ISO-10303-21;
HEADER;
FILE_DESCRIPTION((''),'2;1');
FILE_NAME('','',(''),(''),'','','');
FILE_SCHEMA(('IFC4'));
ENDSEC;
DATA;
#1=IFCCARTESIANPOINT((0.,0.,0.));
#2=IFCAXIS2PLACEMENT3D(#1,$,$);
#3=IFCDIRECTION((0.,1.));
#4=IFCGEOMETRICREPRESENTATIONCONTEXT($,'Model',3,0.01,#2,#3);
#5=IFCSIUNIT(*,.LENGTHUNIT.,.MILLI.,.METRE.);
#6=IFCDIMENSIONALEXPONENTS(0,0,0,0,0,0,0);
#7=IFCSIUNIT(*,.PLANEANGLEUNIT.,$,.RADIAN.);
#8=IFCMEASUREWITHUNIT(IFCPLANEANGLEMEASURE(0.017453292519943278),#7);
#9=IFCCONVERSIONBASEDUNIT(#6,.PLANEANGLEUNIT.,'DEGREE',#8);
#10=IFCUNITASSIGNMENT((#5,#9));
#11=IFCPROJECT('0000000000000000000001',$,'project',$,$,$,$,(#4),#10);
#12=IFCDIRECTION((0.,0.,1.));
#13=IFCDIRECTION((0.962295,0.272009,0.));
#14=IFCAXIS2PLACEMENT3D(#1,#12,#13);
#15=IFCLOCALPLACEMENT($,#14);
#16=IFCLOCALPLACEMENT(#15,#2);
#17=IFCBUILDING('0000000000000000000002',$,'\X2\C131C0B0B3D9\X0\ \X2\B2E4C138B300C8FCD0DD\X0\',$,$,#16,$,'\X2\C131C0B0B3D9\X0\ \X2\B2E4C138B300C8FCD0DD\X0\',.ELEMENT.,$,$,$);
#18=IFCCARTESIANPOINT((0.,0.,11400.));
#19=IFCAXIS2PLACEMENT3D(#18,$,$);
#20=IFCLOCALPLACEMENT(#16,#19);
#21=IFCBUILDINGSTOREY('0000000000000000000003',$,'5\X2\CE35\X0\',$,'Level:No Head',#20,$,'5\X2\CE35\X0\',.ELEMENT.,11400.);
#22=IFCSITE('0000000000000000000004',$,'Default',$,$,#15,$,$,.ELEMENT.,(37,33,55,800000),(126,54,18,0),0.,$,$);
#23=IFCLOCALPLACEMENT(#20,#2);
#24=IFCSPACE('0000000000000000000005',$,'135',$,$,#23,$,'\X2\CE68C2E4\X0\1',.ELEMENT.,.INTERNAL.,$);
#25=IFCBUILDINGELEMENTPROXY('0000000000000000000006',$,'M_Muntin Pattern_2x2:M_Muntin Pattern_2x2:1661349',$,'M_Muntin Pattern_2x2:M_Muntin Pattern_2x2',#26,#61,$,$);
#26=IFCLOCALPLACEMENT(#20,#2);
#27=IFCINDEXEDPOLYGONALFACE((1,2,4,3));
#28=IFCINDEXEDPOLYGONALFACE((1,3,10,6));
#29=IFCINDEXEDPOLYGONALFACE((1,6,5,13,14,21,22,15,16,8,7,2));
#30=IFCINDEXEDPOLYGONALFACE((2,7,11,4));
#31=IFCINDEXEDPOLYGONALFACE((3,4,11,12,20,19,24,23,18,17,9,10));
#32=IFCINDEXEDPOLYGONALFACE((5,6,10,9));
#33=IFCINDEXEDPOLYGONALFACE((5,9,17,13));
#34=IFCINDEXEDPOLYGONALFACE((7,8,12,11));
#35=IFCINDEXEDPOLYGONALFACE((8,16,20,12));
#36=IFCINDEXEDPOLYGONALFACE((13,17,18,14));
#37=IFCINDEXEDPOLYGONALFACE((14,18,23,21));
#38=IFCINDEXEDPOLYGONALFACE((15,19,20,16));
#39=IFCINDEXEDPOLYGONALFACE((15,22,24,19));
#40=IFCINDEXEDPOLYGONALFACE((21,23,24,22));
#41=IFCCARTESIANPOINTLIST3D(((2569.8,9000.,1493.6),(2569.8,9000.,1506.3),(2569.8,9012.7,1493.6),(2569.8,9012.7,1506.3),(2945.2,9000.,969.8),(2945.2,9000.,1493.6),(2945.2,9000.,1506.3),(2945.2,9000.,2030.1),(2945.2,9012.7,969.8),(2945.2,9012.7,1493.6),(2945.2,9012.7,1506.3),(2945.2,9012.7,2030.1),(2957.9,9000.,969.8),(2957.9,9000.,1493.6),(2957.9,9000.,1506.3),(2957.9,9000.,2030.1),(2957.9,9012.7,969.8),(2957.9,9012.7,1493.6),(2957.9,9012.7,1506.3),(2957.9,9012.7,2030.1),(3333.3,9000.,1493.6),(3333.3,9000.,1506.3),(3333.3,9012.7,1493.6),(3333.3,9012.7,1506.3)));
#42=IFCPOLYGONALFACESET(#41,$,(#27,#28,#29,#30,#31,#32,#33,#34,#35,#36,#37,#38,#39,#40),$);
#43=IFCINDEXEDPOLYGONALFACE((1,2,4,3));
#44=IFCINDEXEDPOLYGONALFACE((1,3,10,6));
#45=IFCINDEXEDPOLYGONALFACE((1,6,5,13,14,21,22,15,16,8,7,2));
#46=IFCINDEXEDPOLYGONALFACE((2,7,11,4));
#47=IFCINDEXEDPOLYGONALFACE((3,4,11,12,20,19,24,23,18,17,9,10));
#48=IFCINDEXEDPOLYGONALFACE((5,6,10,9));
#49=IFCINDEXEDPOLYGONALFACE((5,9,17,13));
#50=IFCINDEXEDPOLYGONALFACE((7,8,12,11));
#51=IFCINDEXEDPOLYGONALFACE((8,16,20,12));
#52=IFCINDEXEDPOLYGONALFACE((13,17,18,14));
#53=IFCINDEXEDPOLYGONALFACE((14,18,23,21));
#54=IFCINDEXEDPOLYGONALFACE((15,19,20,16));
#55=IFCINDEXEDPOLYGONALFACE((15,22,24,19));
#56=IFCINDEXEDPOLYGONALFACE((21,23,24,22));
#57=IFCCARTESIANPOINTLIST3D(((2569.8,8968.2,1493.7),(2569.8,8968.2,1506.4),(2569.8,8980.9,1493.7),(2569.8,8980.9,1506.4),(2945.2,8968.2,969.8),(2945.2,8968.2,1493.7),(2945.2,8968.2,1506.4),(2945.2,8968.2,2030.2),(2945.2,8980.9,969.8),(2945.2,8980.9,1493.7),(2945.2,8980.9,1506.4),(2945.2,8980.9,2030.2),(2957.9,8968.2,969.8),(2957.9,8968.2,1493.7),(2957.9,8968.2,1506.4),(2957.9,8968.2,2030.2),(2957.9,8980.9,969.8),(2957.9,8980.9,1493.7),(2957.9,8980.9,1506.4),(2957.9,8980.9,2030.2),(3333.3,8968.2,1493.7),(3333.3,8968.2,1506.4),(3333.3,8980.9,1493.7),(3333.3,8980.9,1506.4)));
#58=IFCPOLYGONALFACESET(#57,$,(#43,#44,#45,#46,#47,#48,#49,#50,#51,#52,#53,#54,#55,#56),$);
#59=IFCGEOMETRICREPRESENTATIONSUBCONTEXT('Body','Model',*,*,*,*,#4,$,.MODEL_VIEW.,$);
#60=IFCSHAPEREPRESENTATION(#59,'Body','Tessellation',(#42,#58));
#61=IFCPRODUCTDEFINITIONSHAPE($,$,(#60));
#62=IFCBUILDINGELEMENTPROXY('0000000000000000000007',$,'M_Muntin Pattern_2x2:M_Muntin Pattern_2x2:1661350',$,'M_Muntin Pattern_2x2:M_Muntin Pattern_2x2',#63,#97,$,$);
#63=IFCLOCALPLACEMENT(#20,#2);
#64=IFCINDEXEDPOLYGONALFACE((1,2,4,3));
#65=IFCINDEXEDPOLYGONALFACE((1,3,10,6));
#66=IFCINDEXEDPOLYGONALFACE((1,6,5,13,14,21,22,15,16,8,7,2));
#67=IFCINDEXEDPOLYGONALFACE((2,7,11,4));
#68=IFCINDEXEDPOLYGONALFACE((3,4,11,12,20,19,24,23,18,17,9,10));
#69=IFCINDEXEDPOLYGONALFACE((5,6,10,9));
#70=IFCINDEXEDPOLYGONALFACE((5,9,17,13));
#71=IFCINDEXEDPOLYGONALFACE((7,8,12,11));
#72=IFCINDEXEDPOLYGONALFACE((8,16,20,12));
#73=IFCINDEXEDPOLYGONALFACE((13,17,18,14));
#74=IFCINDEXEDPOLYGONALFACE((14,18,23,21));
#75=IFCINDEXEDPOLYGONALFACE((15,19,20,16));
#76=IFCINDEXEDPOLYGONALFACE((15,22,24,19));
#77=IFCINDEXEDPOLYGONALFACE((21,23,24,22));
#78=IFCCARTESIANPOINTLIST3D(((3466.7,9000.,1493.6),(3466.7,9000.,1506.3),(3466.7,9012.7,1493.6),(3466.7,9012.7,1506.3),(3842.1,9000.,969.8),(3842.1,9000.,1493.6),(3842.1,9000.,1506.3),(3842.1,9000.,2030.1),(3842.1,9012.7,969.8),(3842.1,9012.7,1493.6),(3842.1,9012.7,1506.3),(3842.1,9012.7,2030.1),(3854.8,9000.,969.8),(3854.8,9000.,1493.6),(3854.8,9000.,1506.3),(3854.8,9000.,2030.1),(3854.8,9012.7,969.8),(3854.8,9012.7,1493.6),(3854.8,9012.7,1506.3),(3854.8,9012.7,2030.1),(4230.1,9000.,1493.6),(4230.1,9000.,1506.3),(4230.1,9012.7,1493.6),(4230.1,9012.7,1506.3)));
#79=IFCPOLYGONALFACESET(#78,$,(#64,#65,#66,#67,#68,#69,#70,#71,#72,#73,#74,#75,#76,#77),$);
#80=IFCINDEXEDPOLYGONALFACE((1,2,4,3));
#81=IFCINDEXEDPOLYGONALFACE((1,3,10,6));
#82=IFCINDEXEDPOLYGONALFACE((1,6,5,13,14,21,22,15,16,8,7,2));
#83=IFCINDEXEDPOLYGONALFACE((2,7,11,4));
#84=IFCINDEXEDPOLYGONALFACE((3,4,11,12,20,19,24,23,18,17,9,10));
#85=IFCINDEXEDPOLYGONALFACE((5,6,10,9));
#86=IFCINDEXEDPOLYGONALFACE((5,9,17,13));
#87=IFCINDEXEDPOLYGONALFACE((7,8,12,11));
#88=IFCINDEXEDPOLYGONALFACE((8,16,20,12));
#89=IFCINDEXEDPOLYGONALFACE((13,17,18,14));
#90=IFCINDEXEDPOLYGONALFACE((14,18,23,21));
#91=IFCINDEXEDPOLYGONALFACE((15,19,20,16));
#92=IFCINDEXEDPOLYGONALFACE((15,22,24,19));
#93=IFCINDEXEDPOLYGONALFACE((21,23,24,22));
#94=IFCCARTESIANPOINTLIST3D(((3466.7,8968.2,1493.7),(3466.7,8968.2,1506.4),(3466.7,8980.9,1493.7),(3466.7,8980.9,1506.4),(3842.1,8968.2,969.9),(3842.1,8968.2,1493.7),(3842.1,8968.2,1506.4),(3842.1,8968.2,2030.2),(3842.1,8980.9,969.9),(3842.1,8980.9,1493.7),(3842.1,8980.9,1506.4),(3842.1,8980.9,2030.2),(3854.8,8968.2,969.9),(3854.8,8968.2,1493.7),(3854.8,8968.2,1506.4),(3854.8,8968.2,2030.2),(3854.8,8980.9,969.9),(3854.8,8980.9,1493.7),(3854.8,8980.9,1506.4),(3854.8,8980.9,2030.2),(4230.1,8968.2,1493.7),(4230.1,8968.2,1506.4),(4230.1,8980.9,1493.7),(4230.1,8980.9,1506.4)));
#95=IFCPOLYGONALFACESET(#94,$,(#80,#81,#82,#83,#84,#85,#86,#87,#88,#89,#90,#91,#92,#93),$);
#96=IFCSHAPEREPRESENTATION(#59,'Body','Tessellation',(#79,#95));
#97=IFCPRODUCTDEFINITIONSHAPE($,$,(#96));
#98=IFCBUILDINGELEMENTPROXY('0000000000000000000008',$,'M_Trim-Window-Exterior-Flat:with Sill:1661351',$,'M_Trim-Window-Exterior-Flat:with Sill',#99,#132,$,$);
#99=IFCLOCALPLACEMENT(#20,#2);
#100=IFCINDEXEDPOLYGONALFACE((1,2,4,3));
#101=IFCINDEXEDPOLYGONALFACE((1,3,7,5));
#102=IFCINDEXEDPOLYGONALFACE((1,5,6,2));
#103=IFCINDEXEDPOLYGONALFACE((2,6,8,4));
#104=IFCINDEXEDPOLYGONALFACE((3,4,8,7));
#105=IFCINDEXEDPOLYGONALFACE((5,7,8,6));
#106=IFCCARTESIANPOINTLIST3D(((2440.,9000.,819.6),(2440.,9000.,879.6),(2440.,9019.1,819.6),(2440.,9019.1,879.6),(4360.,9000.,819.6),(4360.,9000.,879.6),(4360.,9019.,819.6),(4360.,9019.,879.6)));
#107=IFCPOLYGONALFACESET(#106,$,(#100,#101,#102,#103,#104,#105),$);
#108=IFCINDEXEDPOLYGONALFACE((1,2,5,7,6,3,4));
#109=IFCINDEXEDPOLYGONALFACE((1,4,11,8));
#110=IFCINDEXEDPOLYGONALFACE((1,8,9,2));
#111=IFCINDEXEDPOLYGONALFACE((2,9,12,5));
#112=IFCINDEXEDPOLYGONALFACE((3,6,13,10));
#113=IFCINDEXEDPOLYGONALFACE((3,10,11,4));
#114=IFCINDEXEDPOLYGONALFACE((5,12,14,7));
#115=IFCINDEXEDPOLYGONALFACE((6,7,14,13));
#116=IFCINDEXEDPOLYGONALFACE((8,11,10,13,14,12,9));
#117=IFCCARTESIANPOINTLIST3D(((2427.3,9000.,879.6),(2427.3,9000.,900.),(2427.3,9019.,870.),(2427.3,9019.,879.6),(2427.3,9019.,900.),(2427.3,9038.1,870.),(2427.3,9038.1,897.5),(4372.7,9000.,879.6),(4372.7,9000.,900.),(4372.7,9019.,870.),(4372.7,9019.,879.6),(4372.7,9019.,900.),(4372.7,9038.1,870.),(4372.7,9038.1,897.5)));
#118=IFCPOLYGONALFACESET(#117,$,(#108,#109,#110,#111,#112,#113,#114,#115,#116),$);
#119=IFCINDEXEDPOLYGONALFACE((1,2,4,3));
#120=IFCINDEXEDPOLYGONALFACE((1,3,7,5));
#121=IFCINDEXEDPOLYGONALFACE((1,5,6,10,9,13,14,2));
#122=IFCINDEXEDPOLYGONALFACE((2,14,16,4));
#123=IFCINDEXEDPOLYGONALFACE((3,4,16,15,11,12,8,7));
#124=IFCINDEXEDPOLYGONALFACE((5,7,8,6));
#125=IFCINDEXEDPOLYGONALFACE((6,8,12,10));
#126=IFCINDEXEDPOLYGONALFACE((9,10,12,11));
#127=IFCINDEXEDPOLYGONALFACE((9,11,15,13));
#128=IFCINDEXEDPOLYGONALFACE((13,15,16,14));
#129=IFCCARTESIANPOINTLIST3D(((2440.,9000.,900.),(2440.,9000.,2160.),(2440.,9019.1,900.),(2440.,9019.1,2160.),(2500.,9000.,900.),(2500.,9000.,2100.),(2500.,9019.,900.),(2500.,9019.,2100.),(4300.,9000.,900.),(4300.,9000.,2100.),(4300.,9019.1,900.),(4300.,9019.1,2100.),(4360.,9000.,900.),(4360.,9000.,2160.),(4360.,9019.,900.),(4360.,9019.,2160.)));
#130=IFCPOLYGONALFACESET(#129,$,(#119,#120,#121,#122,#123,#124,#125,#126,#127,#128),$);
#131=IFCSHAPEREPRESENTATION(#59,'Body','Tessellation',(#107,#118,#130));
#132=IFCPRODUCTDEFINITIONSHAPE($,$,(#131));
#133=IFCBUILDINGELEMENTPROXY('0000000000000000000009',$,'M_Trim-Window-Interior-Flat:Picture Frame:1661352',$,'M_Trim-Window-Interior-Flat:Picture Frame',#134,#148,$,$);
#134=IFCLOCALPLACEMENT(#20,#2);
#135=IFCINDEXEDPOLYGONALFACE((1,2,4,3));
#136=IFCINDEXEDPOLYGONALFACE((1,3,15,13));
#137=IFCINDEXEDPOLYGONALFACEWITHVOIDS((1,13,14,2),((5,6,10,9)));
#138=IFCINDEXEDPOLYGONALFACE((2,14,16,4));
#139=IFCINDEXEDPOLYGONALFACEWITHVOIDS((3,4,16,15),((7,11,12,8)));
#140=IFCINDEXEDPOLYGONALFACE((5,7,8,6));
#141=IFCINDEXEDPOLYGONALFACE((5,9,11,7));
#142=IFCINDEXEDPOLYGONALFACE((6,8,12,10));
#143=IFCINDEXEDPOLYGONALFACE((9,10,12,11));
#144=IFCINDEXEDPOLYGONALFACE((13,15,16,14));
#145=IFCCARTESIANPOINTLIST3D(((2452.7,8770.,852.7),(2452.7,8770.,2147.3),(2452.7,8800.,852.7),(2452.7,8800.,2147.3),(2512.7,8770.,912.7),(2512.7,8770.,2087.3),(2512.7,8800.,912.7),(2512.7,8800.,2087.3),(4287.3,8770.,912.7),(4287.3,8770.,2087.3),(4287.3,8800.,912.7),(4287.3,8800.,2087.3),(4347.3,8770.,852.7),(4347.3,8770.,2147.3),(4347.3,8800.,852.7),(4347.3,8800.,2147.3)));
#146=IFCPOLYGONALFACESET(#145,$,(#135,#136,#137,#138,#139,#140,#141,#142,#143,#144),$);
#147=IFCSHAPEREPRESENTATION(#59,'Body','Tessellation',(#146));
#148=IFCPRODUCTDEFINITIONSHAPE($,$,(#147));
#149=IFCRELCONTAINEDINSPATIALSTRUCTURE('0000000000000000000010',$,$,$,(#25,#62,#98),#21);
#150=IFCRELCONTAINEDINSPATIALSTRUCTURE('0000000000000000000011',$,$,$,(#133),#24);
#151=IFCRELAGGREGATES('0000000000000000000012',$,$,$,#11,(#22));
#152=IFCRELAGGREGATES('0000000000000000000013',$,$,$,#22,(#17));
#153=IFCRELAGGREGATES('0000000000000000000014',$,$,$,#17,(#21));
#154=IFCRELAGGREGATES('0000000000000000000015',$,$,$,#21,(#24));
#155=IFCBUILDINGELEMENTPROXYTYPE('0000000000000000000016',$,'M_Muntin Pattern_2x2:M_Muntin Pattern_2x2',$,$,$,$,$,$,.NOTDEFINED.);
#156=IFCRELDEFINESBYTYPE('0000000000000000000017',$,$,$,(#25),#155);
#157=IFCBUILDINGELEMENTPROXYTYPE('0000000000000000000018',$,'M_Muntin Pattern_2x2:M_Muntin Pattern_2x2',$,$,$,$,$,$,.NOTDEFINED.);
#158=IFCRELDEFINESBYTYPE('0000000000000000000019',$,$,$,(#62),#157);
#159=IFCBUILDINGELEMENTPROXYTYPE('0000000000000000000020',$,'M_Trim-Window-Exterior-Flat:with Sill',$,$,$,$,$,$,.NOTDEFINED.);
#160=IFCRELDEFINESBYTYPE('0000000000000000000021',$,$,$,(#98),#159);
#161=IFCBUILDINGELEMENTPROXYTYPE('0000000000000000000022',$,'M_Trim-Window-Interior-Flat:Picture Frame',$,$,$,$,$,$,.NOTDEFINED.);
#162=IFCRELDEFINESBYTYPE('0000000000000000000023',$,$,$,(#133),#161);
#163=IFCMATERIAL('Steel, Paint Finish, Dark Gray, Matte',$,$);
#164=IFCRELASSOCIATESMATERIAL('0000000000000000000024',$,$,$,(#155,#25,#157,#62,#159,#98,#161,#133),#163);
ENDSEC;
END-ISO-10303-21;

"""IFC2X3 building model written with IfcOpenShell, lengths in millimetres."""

from ifc_helpers import new_model, entity, si_unit, converted_unit, direction, frame, frame_2d, origin, place, context, subcontext, project, spatial, polyline, rectangle, outline, extrude, source, transform, mapped, material, type_object, type_shapes, element, save


model = new_model("IFC2X3")

# Units and contexts
model_context = context("Model", 3, precision=0.01, world=origin(), true_north=direction((0.0, 1.0)))
body_context = subcontext(model_context, "Body", "Model", "MODEL_VIEW")
ifc_project = project(units=[si_unit("LENGTHUNIT", "METRE", prefix="MILLI"), converted_unit("PLANEANGLEUNIT", "DEGREE", entity("IfcPlaneAngleMeasure", 0.017453292519943278), si_unit("PLANEANGLEUNIT", "RADIAN"), dimensions=[0, 0, 0, 0, 0, 0, 0])], contexts=[model_context])

# Site, building, storey
site_placement = place(None, frame((0.0, 0.0, 0.0), z_axis=(0.0, 0.0, 1.0), x_axis=(0.962295, 0.272009, 0.0)))
site = spatial("IfcSite", under=ifc_project, at=site_placement, Name="Default", CompositionType="ELEMENT", RefLatitude=(37, 33, 55, 800000), RefLongitude=(126, 54, 18, 0), RefElevation=0.0)
building_placement = place(site_placement, origin())
building = spatial("IfcBuilding", under=site, at=building_placement, Name="성산동 다세대주택", LongName="성산동 다세대주택", CompositionType="ELEMENT")
storey_placement = place(building_placement, frame((0.0, 0.0, 11400.0)))
storey = spatial("IfcBuildingStorey", under=building, at=storey_placement, Name="5층", ObjectType="Level:No Head", LongName="5층", CompositionType="ELEMENT", Elevation=11400.0)

# Shared definitions
space_1_placement = place(storey_placement, origin())
space_1 = spatial("IfcSpace", under=storey, at=space_1_placement, Name="135", LongName="침실1", CompositionType="ELEMENT", InteriorOrExteriorSpace="INTERNAL")

# Building element proxies
ifc_material_1 = material(Name="Steel, Paint Finish, Dark Gray, Matte")
building_element_proxy_type_1 = type_object("IfcBuildingElementProxyType", Name="M_Muntin Pattern_2x2:M_Muntin Pattern_2x2", PredefinedType="NOTDEFINED", material=ifc_material_1)
shared_shape_1 = source(origin(), body_context, "Body", "SweptSolid", [
    extrude(outline(polyline([(6.4, -6.4), (530.1, -6.4), (530.1, 6.3), (6.4, 6.3), (6.4, 381.7), (-6.3, 381.7), (-6.3, 6.3), (-530.2, 6.3), (-530.2, -6.4), (-6.3, -6.4), (-6.3, -381.7), (6.4, -381.7), (6.4, -6.4)])), frame((0.0, 9.5, 530.1), z_axis=(0.0, 1.0, 0.0), x_axis=(0.0, 0.0, 1.0)), (0.0, 0.0, 1.0), 12.7),
    extrude(outline(polyline([(6.4, -6.4), (530.2, -6.4), (530.2, 6.3), (6.4, 6.3), (6.4, 381.7), (-6.3, 381.7), (-6.3, 6.3), (-530.2, 6.3), (-530.2, -6.4), (-6.3, -6.4), (-6.3, -381.7), (6.4, -381.7), (6.4, -6.4)])), frame((0.0, -22.2, 530.2), z_axis=(0.0, 1.0, 0.0), x_axis=(0.0, 0.0, 1.0)), (0.0, 0.0, 1.0), 12.7),
])
type_shapes(building_element_proxy_type_1, [shared_shape_1])
proxy_1_placement = place(storey_placement, frame((2951.6, 8990.5, 969.8)))
element("IfcBuildingElementProxy", 1, at=proxy_1_placement, inside=storey, type_object=building_element_proxy_type_1, material=ifc_material_1, Name="M_Muntin Pattern_2x2:M_Muntin Pattern_2x2:1661349", ObjectType="M_Muntin Pattern_2x2:M_Muntin Pattern_2x2", context=body_context, shape_type="MappedRepresentation", body=[
    mapped(shared_shape_1, transform((0.0, 0.0, 0.0), scale=1.0)),
])
building_element_proxy_type_2 = type_object("IfcBuildingElementProxyType", Name="M_Muntin Pattern_2x2:M_Muntin Pattern_2x2", PredefinedType="NOTDEFINED", material=ifc_material_1)
shared_shape_2 = source(origin(), body_context, "Body", "SweptSolid", [
    extrude(outline(polyline([(6.4, -6.4), (530.1, -6.4), (530.1, 6.3), (6.4, 6.3), (6.4, 381.7), (-6.3, 381.7), (-6.3, 6.3), (-530.2, 6.3), (-530.2, -6.4), (-6.3, -6.4), (-6.3, -381.7), (6.4, -381.7), (6.4, -6.4)])), frame((0.0, -22.2, 530.1), z_axis=(0.0, 1.0, 0.0), x_axis=(0.0, 0.0, 1.0)), (0.0, 0.0, 1.0), 12.7),
    extrude(outline(polyline([(6.4, -6.4), (530.2, -6.4), (530.2, 6.3), (6.4, 6.3), (6.4, 381.7), (-6.3, 381.7), (-6.3, 6.3), (-530.2, 6.3), (-530.2, -6.4), (-6.3, -6.4), (-6.3, -381.7), (6.4, -381.7), (6.4, -6.4)])), frame((0.0, 9.5, 530.2), z_axis=(0.0, 1.0, 0.0), x_axis=(0.0, 0.0, 1.0)), (0.0, 0.0, 1.0), 12.7),
])
type_shapes(building_element_proxy_type_2, [shared_shape_2])
proxy_2_placement = place(storey_placement, frame((3848.4, 8990.5, 969.9), z_axis=(0.0, 0.0, 1.0), x_axis=(-1.0, 0.0, 0.0)))
element("IfcBuildingElementProxy", 2, at=proxy_2_placement, inside=storey, type_object=building_element_proxy_type_2, material=ifc_material_1, Name="M_Muntin Pattern_2x2:M_Muntin Pattern_2x2:1661350", ObjectType="M_Muntin Pattern_2x2:M_Muntin Pattern_2x2", context=body_context, shape_type="MappedRepresentation", body=[
    mapped(shared_shape_2, transform((0.0, 0.0, 0.0), scale=1.0)),
])
building_element_proxy_type_3 = type_object("IfcBuildingElementProxyType", Name="M_Trim-Window-Exterior-Flat:with Sill", PredefinedType="NOTDEFINED", material=ifc_material_1)
shared_shape_3 = source(origin(), body_context, "Body", "SweptSolid", [
    extrude(rectangle(XDim=1920.0, YDim=60.0, at=frame_2d((0.0, 0.0), x_axis=(1.0, 0.0))), frame((0.0, -1250.4, 0.0), z_axis=(0.0, 0.0, 1.0), x_axis=(-1.0, 0.0, 0.0)), (0.0, 0.0, 1.0), 19.0),
    extrude(outline(polyline([(-19.0, -15.2), (0.0, -15.2), (0.0, -5.7), (19.0, -5.7), (19.0, 14.8), (0.0, 14.8), (-19.0, 12.3), (-19.0, -15.2)])), frame((-972.7, -1214.8, 19.0), z_axis=(1.0, 0.0, 0.0), x_axis=(0.0, 0.0, -1.0)), (0.0, 0.0, 1.0), 1945.4),
    extrude(outline(polyline([(-645.0, -960.0), (615.0, -960.0), (615.0, -900.0), (-585.0, -900.0), (-585.0, 900.0), (615.0, 900.0), (615.0, 960.0), (-645.0, 960.0), (-645.0, -960.0)])), frame((0.0, -585.0, 0.0), z_axis=(0.0, 0.0, 1.0), x_axis=(0.0, -1.0, 0.0)), (0.0, 0.0, 1.0), 19.0),
])
type_shapes(building_element_proxy_type_3, [shared_shape_3])
proxy_3_placement = place(storey_placement, frame((3400.0, 9000.0, 2100.0), z_axis=(0.0, 1.0, 0.0), x_axis=(-1.0, 0.0, 0.0)))
element("IfcBuildingElementProxy", 3, at=proxy_3_placement, inside=storey, type_object=building_element_proxy_type_3, material=ifc_material_1, Name="M_Trim-Window-Exterior-Flat:with Sill:1661351", ObjectType="M_Trim-Window-Exterior-Flat:with Sill", context=body_context, shape_type="MappedRepresentation", body=[
    mapped(shared_shape_3, transform((0.0, 0.0, 0.0), scale=1.0)),
])
building_element_proxy_type_4 = type_object("IfcBuildingElementProxyType", Name="M_Trim-Window-Interior-Flat:Picture Frame", PredefinedType="NOTDEFINED", material=ifc_material_1)
shared_shape_4 = source(origin(), body_context, "Body", "SweptSolid", [
    extrude(outline(polyline([(-947.3, -647.3), (947.3, -647.3), (947.3, 647.3), (-947.3, 647.3), (-947.3, -647.3)]), holes=[polyline([(-887.3, -587.3), (-887.3, 587.3), (887.3, 587.3), (887.3, -587.3), (-887.3, -587.3)])]), frame((0.0, -600.0, 0.0), z_axis=(0.0, 0.0, 1.0), x_axis=(-1.0, 0.0, 0.0)), (0.0, 0.0, 1.0), 30.0),
])
type_shapes(building_element_proxy_type_4, [shared_shape_4])
proxy_4_placement = place(space_1_placement, frame((3400.0, 8800.0, 2100.0), z_axis=(0.0, -1.0, 0.0), x_axis=(1.0, 0.0, 0.0)))
element("IfcBuildingElementProxy", 4, at=proxy_4_placement, inside=space_1, type_object=building_element_proxy_type_4, material=ifc_material_1, Name="M_Trim-Window-Interior-Flat:Picture Frame:1661352", ObjectType="M_Trim-Window-Interior-Flat:Picture Frame", context=body_context, shape_type="MappedRepresentation", body=[
    mapped(shared_shape_4, transform((0.0, 0.0, 0.0), scale=1.0)),
])

save(model, "model.ifc")
